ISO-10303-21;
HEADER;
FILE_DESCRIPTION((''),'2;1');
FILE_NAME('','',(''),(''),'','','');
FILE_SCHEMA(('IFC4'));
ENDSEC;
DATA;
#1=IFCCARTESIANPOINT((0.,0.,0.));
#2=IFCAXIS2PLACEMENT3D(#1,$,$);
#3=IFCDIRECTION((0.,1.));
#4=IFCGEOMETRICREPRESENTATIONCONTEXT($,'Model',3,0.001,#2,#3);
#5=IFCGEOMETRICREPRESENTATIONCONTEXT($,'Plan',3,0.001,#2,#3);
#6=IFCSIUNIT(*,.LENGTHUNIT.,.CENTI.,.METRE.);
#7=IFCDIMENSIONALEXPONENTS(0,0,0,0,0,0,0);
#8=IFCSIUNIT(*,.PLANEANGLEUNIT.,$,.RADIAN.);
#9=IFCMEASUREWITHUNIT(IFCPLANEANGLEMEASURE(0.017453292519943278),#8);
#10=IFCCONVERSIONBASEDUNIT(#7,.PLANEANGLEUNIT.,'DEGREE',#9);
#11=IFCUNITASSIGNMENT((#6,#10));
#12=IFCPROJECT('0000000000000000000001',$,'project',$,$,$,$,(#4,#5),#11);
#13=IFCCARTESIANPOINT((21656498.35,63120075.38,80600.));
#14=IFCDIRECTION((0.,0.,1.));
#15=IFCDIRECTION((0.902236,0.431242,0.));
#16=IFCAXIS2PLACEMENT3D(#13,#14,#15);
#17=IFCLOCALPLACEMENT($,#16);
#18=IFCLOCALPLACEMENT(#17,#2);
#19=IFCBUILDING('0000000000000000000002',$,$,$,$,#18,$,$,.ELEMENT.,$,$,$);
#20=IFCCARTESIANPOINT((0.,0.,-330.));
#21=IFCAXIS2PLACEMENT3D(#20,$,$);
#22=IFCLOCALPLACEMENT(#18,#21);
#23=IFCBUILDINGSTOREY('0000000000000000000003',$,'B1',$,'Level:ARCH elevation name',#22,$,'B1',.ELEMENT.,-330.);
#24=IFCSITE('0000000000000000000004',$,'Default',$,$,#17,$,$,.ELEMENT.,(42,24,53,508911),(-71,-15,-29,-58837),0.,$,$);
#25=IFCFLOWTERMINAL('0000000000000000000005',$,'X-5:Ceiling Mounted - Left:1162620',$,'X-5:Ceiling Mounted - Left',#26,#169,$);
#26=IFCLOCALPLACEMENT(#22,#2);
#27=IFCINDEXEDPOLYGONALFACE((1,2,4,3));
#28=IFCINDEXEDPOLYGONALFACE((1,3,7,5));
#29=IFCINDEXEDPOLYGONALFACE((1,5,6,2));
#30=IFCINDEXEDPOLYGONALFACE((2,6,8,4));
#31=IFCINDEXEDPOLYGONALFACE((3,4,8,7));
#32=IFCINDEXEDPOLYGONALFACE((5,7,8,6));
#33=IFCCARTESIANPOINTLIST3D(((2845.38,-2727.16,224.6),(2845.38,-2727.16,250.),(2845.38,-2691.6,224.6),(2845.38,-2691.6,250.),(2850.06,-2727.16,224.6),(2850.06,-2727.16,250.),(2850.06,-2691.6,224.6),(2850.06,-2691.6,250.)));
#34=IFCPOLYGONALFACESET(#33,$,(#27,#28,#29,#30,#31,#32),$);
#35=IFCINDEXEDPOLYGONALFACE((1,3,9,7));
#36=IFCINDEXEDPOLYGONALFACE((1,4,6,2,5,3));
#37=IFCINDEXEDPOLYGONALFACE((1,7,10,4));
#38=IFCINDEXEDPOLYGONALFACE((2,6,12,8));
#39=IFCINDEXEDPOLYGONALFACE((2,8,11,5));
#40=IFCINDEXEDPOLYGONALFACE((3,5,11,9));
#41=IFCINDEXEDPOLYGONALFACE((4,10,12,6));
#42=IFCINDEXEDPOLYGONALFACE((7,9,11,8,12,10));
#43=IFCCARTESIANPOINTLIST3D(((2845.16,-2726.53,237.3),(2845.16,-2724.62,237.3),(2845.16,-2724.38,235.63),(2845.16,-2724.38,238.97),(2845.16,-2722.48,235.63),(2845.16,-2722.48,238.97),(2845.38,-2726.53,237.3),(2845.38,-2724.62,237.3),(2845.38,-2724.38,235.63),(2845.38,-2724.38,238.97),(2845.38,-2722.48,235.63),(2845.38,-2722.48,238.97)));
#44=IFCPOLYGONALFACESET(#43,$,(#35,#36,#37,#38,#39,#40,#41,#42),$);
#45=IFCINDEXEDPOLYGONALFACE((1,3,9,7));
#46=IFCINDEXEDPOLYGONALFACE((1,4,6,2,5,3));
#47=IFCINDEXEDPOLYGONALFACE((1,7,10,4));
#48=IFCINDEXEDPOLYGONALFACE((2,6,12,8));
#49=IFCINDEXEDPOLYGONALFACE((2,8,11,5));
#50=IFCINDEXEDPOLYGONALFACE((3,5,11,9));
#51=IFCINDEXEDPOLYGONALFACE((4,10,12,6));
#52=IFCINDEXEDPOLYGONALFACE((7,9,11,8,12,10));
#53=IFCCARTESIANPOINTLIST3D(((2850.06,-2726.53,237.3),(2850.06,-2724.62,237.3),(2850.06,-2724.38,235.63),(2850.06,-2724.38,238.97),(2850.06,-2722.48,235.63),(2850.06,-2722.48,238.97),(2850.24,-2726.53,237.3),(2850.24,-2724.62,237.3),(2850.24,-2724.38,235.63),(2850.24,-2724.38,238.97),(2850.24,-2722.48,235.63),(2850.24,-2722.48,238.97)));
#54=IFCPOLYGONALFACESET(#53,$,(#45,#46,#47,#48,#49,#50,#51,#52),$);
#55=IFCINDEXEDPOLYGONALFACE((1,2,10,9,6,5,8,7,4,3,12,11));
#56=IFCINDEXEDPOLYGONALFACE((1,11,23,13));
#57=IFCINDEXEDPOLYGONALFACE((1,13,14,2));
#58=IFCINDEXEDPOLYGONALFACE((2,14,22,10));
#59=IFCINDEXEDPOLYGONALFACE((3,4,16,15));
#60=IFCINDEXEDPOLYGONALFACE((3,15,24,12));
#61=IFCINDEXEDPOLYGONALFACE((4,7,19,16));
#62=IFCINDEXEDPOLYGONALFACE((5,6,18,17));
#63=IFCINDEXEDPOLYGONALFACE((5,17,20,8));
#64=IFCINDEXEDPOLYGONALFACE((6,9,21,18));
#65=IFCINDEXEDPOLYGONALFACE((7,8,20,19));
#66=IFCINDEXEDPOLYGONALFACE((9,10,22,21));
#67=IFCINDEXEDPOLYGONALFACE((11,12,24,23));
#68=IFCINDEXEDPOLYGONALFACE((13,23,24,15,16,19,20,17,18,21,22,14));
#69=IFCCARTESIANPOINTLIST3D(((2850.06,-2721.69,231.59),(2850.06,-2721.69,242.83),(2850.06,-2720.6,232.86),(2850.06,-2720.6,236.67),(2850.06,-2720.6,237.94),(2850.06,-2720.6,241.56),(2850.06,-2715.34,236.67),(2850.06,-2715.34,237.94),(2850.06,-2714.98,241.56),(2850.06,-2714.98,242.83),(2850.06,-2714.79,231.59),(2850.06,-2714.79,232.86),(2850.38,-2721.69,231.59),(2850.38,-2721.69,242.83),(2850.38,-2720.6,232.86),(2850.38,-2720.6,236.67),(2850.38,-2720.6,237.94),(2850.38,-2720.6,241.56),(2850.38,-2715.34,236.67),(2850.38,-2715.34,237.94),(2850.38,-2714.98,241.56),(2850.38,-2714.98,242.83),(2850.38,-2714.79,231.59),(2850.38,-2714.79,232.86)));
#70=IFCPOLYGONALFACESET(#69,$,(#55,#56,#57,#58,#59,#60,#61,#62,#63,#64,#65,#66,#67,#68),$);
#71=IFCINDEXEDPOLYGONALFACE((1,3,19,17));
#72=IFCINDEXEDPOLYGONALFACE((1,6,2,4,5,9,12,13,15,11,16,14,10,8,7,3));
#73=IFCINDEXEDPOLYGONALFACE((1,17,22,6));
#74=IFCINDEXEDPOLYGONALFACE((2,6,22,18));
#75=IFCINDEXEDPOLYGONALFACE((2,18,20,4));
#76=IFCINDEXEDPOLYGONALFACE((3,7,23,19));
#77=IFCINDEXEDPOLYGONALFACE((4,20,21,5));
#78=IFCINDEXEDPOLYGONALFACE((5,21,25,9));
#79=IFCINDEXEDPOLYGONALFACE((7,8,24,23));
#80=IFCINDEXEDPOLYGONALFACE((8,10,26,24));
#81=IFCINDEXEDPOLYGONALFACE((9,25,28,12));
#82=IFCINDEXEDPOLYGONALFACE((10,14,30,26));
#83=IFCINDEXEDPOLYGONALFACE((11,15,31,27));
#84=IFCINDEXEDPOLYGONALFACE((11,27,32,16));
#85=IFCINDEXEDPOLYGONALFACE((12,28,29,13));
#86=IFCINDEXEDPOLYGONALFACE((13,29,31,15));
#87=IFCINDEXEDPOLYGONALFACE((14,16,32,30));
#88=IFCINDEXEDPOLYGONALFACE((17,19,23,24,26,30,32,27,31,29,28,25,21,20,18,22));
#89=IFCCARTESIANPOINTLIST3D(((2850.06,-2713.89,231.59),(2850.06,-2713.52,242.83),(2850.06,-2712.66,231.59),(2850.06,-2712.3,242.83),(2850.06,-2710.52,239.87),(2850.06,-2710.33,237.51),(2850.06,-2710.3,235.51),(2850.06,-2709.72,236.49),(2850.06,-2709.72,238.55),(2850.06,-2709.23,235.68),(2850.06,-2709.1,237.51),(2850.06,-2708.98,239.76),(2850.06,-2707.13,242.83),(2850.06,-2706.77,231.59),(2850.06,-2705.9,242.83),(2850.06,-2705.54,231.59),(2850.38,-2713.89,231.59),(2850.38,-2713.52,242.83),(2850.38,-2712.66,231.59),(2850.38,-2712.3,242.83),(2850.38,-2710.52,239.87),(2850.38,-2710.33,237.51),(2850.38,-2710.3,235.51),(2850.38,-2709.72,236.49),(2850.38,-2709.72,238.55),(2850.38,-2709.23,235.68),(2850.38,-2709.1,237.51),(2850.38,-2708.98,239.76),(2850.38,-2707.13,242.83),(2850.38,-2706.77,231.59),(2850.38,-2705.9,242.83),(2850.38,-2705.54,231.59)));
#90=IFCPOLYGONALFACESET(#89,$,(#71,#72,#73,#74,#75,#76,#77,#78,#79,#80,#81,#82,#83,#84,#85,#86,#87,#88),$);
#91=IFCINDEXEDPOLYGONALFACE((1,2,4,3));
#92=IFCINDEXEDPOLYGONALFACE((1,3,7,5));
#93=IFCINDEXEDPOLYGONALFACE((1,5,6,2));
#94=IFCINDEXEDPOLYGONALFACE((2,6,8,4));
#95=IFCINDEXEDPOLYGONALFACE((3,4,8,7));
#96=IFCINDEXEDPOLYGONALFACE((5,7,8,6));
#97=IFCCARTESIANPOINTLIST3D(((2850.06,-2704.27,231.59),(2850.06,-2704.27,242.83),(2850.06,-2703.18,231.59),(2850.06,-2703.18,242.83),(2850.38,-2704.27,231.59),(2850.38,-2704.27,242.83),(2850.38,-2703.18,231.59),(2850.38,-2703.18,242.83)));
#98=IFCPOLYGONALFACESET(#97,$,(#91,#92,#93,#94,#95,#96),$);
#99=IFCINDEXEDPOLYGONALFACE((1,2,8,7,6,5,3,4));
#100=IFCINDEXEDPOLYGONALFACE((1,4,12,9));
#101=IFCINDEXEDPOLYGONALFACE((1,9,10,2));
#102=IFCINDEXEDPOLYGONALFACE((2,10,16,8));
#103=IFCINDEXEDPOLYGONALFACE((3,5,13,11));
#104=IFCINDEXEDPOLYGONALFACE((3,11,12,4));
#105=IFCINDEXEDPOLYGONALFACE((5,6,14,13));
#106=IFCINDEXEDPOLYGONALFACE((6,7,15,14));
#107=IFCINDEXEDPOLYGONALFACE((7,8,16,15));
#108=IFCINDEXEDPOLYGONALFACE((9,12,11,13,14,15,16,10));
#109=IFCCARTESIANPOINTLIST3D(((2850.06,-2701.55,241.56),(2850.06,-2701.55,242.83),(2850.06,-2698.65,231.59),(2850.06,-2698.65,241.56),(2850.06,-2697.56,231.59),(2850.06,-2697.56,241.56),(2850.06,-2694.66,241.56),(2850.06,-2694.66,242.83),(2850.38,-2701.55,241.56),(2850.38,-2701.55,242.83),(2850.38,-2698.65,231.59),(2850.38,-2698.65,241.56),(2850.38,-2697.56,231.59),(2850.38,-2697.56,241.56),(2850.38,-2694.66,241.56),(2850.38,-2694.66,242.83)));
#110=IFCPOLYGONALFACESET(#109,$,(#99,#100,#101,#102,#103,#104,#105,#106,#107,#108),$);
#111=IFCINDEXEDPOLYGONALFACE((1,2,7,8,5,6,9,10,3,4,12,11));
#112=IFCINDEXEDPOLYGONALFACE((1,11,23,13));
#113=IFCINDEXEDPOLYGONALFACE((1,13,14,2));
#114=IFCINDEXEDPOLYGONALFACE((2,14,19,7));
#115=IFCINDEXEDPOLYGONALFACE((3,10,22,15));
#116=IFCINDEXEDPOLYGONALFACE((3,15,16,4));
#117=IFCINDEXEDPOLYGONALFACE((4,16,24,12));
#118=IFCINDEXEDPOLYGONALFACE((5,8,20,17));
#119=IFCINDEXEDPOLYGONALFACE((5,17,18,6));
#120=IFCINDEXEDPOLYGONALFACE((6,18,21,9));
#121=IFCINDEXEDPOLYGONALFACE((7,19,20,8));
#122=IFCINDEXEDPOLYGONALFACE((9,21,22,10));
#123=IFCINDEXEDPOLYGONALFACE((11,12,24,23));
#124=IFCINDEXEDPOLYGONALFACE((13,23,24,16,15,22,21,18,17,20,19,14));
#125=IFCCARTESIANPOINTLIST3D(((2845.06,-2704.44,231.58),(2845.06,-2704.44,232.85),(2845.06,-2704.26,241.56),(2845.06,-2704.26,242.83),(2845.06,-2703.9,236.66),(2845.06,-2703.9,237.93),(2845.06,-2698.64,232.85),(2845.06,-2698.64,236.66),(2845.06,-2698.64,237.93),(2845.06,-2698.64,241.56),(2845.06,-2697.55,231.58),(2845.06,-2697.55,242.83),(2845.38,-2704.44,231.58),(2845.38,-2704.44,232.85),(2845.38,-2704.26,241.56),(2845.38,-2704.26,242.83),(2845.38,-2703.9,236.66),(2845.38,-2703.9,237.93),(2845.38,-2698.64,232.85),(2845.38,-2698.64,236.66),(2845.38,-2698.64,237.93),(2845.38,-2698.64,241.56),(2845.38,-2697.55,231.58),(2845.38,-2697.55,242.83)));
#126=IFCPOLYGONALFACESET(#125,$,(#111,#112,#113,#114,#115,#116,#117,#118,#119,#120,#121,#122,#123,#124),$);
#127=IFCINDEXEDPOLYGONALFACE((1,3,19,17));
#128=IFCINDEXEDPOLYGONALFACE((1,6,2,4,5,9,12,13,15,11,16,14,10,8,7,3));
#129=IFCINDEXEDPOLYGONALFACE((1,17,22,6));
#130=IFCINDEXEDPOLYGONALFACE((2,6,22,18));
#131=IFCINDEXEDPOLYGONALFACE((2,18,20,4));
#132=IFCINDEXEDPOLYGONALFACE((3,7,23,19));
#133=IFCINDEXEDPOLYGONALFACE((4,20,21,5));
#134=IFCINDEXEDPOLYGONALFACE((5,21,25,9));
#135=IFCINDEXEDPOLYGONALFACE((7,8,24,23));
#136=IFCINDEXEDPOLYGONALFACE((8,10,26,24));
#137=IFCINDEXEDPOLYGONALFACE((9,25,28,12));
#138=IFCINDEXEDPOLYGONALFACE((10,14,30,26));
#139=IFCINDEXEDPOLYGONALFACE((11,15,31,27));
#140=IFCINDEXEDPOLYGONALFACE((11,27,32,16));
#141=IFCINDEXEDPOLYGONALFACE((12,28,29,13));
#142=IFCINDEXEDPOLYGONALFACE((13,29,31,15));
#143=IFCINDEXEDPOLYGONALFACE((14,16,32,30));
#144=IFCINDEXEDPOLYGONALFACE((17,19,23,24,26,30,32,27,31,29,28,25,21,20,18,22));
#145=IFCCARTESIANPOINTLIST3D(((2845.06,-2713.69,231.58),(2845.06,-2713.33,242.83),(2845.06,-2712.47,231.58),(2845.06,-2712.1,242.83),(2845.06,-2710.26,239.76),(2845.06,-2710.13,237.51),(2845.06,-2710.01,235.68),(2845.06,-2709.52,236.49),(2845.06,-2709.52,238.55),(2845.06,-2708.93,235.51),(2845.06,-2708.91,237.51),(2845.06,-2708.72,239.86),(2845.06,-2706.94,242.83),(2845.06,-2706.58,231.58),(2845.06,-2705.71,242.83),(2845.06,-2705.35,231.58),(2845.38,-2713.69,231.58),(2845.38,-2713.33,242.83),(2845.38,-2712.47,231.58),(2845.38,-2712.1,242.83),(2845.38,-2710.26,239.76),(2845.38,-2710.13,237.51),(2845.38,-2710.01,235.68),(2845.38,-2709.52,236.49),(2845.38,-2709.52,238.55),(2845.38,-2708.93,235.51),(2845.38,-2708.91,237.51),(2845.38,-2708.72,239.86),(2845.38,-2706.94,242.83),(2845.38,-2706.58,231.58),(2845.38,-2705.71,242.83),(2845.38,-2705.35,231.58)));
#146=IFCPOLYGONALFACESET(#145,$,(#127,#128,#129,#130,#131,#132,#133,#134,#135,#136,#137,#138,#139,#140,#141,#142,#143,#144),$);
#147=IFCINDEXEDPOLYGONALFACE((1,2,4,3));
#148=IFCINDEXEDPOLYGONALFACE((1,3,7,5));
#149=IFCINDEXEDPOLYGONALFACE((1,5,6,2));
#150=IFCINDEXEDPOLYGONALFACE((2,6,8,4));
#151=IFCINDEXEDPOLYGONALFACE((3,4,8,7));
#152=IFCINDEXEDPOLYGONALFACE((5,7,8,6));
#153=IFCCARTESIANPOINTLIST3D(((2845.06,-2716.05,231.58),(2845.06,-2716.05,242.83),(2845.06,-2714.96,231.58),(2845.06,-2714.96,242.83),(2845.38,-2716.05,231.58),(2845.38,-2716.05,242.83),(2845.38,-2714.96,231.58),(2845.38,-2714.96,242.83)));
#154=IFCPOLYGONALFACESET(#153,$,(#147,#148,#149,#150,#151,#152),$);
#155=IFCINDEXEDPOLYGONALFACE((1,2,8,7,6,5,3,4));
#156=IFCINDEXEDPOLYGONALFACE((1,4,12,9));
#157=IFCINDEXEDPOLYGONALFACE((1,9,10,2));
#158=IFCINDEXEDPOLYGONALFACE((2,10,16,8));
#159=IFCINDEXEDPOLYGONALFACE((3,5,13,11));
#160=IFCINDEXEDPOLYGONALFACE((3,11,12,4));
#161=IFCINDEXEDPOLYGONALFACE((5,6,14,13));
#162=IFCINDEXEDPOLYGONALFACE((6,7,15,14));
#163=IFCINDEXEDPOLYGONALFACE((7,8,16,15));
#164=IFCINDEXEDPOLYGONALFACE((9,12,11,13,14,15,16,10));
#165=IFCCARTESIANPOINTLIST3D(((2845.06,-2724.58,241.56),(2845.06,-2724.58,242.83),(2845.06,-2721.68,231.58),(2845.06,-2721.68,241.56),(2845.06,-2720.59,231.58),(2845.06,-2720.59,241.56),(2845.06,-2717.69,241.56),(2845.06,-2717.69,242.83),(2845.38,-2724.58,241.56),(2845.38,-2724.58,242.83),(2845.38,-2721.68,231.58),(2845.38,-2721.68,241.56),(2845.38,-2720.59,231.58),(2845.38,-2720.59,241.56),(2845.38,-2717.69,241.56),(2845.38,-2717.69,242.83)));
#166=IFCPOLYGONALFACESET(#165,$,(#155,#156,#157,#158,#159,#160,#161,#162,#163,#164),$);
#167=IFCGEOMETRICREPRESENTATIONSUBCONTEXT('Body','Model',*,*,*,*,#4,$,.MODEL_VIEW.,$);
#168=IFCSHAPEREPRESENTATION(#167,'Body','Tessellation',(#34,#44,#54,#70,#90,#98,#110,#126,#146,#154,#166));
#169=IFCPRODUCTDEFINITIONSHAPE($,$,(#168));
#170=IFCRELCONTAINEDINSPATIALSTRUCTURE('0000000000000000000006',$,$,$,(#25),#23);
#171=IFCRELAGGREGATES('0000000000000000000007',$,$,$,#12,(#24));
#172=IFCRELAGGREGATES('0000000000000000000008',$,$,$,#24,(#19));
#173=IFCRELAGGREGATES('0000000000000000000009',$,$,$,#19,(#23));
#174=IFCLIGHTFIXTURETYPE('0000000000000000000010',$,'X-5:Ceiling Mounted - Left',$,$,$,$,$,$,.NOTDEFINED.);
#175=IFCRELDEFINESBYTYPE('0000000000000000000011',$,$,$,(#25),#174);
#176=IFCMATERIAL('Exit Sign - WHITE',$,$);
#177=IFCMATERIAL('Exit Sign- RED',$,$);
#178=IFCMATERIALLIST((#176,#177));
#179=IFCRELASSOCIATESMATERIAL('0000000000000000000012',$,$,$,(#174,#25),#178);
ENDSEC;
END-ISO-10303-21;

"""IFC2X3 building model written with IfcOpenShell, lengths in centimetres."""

from ifc_helpers import new_model, entity, si_unit, converted_unit, direction, frame, frame_2d, origin, place, context, subcontext, project, spatial, polyline, rectangle, outline, extrude, source, transform, mapped, material, material_list, type_object, type_shapes, element, save


model = new_model("IFC2X3")

# Units and contexts
model_context = context("Model", 3, precision=0.001, world=origin(), true_north=direction((0.0, 1.0)))
plan_context = context("Plan", 3, precision=0.001, world=origin(), true_north=direction((0.0, 1.0)))
body_context = subcontext(model_context, "Body", "Model", "MODEL_VIEW")
ifc_project = project(units=[si_unit("LENGTHUNIT", "METRE", prefix="CENTI"), converted_unit("PLANEANGLEUNIT", "DEGREE", entity("IfcPlaneAngleMeasure", 0.017453292519943278), si_unit("PLANEANGLEUNIT", "RADIAN"), dimensions=[0, 0, 0, 0, 0, 0, 0])], contexts=[model_context, plan_context])

# Site, building, storey
site_placement = place(None, frame((21656498.35, 63120075.38, 80600.0), z_axis=(0.0, 0.0, 1.0), x_axis=(0.902236, 0.431242, 0.0)))
site = spatial("IfcSite", under=ifc_project, at=site_placement, Name="Default", CompositionType="ELEMENT", RefLatitude=(42, 24, 53, 508911), RefLongitude=(-71, -15, -29, -58837), RefElevation=0.0)
building_placement = place(site_placement, origin())
building = spatial("IfcBuilding", under=site, at=building_placement, CompositionType="ELEMENT")
storey_placement = place(building_placement, frame((0.0, 0.0, -330.0)))
storey = spatial("IfcBuildingStorey", under=building, at=storey_placement, Name="B1", ObjectType="Level:ARCH elevation name", LongName="B1", CompositionType="ELEMENT", Elevation=-330.0)

# Flow terminal
ifc_material_1 = material(Name="Exit Sign - WHITE")
ifc_material_2 = material(Name="Exit Sign- RED")
ifc_material_list_1 = material_list([ifc_material_1, ifc_material_2])
light_fixture_type_1 = type_object("IfcLightFixtureType", Name="X-5:Ceiling Mounted - Left", PredefinedType="NOTDEFINED", material=ifc_material_list_1)
shared_shape_1 = source(origin(), body_context, "Body", "SweptSolid", [
    extrude(rectangle(XDim=4.68, YDim=35.56, at=frame_2d((0.0, 0.0), x_axis=(1.0, 0.0))), frame((0.0, 1.02, -25.4), z_axis=(0.0, 0.0, 1.0), x_axis=(0.0, 1.0, 0.0)), (0.0, 0.0, 1.0), 25.4),
    extrude(outline(polyline([(-0.24, -1.67), (1.67, -1.67), (-0.47, 0.0), (1.67, 1.67), (-0.24, 1.67), (-2.38, 0.0), (-0.24, -1.67)])), frame((-14.77, 3.36, -12.7), z_axis=(0.0, 1.0, 0.0), x_axis=(1.0, 0.0, 0.0)), (0.0, 0.0, 1.0), 0.22),
    extrude(outline(polyline([(-0.24, -1.67), (1.67, -1.67), (-0.47, 0.0), (1.67, 1.67), (-0.24, 1.67), (-2.38, 0.0), (-0.24, -1.67)])), frame((-14.77, -1.49, -12.7), z_axis=(0.0, 1.0, 0.0), x_axis=(1.0, 0.0, 0.0)), (0.0, 0.0, 1.0), 0.18),
    extrude(outline(polyline([(-5.65, -3.69), (5.59, -3.69), (5.59, 3.02), (4.32, 3.02), (4.32, -2.6), (0.7, -2.6), (0.7, 2.66), (-0.57, 2.66), (-0.57, -2.6), (-4.38, -2.6), (-4.38, 3.21), (-5.65, 3.21), (-5.65, -3.69)])), frame((-8.62, -1.63, -12.76), z_axis=(0.0, 1.0, 0.0), x_axis=(0.0, 0.0, 1.0)), (0.0, 0.0, 1.0), 0.32),
    extrude(outline(polyline([(-7.14, 0.57), (-6.5, -0.49), (-1.93, -0.48), (-0.78, -0.48), (-1.23, -1.32), (-3.47, -5.53), (-2.84, -6.59), (0.41, -0.48), (6.62, -0.48), (5.99, 0.57), (2.4, 0.57), (0.98, 0.58), (1.7, 1.94), (3.32, 5.0), (2.69, 6.05), (-0.22, 0.57), (-7.14, 0.57)])), frame((-0.34, -1.63, -12.59), z_axis=(0.0, -1.0, 0.0), x_axis=(0.515099, 0.0, 0.857131)), (0.0, 0.0, -1.0), 0.32),
    extrude(rectangle(XDim=0.32, YDim=1.09, at=frame_2d((0.0, 0.0), x_axis=(1.0, 0.0))), frame((5.65, -1.48, -18.41), z_axis=(0.0, 0.0, 1.0), x_axis=(0.0, 1.0, 0.0)), (0.0, 0.0, 1.0), 11.25),
    extrude(outline(polyline([(-7.8, 0.54), (-7.8, -0.54), (2.18, -0.54), (2.18, -3.45), (3.45, -3.45), (3.45, 3.45), (2.18, 3.45), (2.18, 0.54), (-7.8, 0.54)])), frame((11.28, -1.63, -10.61), z_axis=(0.0, -1.0, 0.0), x_axis=(0.0, 0.0, 1.0)), (0.0, 0.0, -1.0), 0.32),
    extrude(outline(polyline([(-3.69, -5.65), (3.21, -5.65), (3.21, -4.38), (-2.6, -4.38), (-2.6, -0.57), (2.66, -0.57), (2.66, 0.7), (-2.6, 0.7), (-2.6, 4.32), (3.02, 4.32), (3.02, 5.59), (-3.69, 5.59), (-3.69, -5.65)])), frame((8.14, 3.36, -12.76), z_axis=(0.0, 1.0, 0.0), x_axis=(-1.0, 0.0, 0.0)), (0.0, 0.0, 1.0), 0.32),
    extrude(outline(polyline([(-4.16, -5.82), (-2.93, -5.82), (-0.58, -1.9), (0.01, -0.92), (0.5, -1.73), (2.96, -5.82), (4.18, -5.82), (0.62, 0.1), (3.82, 5.42), (2.59, 5.42), (0.75, 2.35), (0.01, 1.14), (-0.79, 2.46), (-2.57, 5.42), (-3.8, 5.42), (-0.6, 0.1), (-4.16, -5.82)])), frame((-0.13, 3.36, -12.59), z_axis=(0.0, 1.0, 0.0), x_axis=(-1.0, 0.0, 0.0)), (0.0, 0.0, 1.0), 0.32),
    extrude(rectangle(XDim=0.32, YDim=1.09, at=frame_2d((0.0, 0.0), x_axis=(1.0, 0.0))), frame((-6.13, 3.52, -18.42), z_axis=(0.0, 0.0, 1.0), x_axis=(0.0, -1.0, 0.0)), (0.0, 0.0, 1.0), 11.25),
    extrude(outline(polyline([(-0.54, -7.8), (0.54, -7.8), (0.54, 2.18), (3.45, 2.18), (3.45, 3.45), (-3.45, 3.45), (-3.45, 2.18), (-0.54, 2.18), (-0.54, -7.8)])), frame((-11.75, 3.36, -10.62), z_axis=(0.0, 1.0, 0.0), x_axis=(-1.0, 0.0, 0.0)), (0.0, 0.0, 1.0), 0.32),
])
type_shapes(light_fixture_type_1, [shared_shape_1])
for number, where, z_axis, x_axis, name in (
    (1, (2848.74, -2709.38, 250.0), (0.0, 0.0, 1.0), (0.0, 1.0, 0.0), "X-5:Ceiling Mounted - Left:1162620"),
):
    element("IfcFlowTerminal", number, at=place(storey_placement, frame(where, z_axis=z_axis, x_axis=x_axis)), inside=storey, type_object=light_fixture_type_1, material=ifc_material_list_1, Name=name, ObjectType="X-5:Ceiling Mounted - Left", context=body_context, shape_type="MappedRepresentation", body=[
        mapped(shared_shape_1, transform((0.0, 0.0, 0.0), scale=1.0)),
    ])

save(model, "model.ifc")
